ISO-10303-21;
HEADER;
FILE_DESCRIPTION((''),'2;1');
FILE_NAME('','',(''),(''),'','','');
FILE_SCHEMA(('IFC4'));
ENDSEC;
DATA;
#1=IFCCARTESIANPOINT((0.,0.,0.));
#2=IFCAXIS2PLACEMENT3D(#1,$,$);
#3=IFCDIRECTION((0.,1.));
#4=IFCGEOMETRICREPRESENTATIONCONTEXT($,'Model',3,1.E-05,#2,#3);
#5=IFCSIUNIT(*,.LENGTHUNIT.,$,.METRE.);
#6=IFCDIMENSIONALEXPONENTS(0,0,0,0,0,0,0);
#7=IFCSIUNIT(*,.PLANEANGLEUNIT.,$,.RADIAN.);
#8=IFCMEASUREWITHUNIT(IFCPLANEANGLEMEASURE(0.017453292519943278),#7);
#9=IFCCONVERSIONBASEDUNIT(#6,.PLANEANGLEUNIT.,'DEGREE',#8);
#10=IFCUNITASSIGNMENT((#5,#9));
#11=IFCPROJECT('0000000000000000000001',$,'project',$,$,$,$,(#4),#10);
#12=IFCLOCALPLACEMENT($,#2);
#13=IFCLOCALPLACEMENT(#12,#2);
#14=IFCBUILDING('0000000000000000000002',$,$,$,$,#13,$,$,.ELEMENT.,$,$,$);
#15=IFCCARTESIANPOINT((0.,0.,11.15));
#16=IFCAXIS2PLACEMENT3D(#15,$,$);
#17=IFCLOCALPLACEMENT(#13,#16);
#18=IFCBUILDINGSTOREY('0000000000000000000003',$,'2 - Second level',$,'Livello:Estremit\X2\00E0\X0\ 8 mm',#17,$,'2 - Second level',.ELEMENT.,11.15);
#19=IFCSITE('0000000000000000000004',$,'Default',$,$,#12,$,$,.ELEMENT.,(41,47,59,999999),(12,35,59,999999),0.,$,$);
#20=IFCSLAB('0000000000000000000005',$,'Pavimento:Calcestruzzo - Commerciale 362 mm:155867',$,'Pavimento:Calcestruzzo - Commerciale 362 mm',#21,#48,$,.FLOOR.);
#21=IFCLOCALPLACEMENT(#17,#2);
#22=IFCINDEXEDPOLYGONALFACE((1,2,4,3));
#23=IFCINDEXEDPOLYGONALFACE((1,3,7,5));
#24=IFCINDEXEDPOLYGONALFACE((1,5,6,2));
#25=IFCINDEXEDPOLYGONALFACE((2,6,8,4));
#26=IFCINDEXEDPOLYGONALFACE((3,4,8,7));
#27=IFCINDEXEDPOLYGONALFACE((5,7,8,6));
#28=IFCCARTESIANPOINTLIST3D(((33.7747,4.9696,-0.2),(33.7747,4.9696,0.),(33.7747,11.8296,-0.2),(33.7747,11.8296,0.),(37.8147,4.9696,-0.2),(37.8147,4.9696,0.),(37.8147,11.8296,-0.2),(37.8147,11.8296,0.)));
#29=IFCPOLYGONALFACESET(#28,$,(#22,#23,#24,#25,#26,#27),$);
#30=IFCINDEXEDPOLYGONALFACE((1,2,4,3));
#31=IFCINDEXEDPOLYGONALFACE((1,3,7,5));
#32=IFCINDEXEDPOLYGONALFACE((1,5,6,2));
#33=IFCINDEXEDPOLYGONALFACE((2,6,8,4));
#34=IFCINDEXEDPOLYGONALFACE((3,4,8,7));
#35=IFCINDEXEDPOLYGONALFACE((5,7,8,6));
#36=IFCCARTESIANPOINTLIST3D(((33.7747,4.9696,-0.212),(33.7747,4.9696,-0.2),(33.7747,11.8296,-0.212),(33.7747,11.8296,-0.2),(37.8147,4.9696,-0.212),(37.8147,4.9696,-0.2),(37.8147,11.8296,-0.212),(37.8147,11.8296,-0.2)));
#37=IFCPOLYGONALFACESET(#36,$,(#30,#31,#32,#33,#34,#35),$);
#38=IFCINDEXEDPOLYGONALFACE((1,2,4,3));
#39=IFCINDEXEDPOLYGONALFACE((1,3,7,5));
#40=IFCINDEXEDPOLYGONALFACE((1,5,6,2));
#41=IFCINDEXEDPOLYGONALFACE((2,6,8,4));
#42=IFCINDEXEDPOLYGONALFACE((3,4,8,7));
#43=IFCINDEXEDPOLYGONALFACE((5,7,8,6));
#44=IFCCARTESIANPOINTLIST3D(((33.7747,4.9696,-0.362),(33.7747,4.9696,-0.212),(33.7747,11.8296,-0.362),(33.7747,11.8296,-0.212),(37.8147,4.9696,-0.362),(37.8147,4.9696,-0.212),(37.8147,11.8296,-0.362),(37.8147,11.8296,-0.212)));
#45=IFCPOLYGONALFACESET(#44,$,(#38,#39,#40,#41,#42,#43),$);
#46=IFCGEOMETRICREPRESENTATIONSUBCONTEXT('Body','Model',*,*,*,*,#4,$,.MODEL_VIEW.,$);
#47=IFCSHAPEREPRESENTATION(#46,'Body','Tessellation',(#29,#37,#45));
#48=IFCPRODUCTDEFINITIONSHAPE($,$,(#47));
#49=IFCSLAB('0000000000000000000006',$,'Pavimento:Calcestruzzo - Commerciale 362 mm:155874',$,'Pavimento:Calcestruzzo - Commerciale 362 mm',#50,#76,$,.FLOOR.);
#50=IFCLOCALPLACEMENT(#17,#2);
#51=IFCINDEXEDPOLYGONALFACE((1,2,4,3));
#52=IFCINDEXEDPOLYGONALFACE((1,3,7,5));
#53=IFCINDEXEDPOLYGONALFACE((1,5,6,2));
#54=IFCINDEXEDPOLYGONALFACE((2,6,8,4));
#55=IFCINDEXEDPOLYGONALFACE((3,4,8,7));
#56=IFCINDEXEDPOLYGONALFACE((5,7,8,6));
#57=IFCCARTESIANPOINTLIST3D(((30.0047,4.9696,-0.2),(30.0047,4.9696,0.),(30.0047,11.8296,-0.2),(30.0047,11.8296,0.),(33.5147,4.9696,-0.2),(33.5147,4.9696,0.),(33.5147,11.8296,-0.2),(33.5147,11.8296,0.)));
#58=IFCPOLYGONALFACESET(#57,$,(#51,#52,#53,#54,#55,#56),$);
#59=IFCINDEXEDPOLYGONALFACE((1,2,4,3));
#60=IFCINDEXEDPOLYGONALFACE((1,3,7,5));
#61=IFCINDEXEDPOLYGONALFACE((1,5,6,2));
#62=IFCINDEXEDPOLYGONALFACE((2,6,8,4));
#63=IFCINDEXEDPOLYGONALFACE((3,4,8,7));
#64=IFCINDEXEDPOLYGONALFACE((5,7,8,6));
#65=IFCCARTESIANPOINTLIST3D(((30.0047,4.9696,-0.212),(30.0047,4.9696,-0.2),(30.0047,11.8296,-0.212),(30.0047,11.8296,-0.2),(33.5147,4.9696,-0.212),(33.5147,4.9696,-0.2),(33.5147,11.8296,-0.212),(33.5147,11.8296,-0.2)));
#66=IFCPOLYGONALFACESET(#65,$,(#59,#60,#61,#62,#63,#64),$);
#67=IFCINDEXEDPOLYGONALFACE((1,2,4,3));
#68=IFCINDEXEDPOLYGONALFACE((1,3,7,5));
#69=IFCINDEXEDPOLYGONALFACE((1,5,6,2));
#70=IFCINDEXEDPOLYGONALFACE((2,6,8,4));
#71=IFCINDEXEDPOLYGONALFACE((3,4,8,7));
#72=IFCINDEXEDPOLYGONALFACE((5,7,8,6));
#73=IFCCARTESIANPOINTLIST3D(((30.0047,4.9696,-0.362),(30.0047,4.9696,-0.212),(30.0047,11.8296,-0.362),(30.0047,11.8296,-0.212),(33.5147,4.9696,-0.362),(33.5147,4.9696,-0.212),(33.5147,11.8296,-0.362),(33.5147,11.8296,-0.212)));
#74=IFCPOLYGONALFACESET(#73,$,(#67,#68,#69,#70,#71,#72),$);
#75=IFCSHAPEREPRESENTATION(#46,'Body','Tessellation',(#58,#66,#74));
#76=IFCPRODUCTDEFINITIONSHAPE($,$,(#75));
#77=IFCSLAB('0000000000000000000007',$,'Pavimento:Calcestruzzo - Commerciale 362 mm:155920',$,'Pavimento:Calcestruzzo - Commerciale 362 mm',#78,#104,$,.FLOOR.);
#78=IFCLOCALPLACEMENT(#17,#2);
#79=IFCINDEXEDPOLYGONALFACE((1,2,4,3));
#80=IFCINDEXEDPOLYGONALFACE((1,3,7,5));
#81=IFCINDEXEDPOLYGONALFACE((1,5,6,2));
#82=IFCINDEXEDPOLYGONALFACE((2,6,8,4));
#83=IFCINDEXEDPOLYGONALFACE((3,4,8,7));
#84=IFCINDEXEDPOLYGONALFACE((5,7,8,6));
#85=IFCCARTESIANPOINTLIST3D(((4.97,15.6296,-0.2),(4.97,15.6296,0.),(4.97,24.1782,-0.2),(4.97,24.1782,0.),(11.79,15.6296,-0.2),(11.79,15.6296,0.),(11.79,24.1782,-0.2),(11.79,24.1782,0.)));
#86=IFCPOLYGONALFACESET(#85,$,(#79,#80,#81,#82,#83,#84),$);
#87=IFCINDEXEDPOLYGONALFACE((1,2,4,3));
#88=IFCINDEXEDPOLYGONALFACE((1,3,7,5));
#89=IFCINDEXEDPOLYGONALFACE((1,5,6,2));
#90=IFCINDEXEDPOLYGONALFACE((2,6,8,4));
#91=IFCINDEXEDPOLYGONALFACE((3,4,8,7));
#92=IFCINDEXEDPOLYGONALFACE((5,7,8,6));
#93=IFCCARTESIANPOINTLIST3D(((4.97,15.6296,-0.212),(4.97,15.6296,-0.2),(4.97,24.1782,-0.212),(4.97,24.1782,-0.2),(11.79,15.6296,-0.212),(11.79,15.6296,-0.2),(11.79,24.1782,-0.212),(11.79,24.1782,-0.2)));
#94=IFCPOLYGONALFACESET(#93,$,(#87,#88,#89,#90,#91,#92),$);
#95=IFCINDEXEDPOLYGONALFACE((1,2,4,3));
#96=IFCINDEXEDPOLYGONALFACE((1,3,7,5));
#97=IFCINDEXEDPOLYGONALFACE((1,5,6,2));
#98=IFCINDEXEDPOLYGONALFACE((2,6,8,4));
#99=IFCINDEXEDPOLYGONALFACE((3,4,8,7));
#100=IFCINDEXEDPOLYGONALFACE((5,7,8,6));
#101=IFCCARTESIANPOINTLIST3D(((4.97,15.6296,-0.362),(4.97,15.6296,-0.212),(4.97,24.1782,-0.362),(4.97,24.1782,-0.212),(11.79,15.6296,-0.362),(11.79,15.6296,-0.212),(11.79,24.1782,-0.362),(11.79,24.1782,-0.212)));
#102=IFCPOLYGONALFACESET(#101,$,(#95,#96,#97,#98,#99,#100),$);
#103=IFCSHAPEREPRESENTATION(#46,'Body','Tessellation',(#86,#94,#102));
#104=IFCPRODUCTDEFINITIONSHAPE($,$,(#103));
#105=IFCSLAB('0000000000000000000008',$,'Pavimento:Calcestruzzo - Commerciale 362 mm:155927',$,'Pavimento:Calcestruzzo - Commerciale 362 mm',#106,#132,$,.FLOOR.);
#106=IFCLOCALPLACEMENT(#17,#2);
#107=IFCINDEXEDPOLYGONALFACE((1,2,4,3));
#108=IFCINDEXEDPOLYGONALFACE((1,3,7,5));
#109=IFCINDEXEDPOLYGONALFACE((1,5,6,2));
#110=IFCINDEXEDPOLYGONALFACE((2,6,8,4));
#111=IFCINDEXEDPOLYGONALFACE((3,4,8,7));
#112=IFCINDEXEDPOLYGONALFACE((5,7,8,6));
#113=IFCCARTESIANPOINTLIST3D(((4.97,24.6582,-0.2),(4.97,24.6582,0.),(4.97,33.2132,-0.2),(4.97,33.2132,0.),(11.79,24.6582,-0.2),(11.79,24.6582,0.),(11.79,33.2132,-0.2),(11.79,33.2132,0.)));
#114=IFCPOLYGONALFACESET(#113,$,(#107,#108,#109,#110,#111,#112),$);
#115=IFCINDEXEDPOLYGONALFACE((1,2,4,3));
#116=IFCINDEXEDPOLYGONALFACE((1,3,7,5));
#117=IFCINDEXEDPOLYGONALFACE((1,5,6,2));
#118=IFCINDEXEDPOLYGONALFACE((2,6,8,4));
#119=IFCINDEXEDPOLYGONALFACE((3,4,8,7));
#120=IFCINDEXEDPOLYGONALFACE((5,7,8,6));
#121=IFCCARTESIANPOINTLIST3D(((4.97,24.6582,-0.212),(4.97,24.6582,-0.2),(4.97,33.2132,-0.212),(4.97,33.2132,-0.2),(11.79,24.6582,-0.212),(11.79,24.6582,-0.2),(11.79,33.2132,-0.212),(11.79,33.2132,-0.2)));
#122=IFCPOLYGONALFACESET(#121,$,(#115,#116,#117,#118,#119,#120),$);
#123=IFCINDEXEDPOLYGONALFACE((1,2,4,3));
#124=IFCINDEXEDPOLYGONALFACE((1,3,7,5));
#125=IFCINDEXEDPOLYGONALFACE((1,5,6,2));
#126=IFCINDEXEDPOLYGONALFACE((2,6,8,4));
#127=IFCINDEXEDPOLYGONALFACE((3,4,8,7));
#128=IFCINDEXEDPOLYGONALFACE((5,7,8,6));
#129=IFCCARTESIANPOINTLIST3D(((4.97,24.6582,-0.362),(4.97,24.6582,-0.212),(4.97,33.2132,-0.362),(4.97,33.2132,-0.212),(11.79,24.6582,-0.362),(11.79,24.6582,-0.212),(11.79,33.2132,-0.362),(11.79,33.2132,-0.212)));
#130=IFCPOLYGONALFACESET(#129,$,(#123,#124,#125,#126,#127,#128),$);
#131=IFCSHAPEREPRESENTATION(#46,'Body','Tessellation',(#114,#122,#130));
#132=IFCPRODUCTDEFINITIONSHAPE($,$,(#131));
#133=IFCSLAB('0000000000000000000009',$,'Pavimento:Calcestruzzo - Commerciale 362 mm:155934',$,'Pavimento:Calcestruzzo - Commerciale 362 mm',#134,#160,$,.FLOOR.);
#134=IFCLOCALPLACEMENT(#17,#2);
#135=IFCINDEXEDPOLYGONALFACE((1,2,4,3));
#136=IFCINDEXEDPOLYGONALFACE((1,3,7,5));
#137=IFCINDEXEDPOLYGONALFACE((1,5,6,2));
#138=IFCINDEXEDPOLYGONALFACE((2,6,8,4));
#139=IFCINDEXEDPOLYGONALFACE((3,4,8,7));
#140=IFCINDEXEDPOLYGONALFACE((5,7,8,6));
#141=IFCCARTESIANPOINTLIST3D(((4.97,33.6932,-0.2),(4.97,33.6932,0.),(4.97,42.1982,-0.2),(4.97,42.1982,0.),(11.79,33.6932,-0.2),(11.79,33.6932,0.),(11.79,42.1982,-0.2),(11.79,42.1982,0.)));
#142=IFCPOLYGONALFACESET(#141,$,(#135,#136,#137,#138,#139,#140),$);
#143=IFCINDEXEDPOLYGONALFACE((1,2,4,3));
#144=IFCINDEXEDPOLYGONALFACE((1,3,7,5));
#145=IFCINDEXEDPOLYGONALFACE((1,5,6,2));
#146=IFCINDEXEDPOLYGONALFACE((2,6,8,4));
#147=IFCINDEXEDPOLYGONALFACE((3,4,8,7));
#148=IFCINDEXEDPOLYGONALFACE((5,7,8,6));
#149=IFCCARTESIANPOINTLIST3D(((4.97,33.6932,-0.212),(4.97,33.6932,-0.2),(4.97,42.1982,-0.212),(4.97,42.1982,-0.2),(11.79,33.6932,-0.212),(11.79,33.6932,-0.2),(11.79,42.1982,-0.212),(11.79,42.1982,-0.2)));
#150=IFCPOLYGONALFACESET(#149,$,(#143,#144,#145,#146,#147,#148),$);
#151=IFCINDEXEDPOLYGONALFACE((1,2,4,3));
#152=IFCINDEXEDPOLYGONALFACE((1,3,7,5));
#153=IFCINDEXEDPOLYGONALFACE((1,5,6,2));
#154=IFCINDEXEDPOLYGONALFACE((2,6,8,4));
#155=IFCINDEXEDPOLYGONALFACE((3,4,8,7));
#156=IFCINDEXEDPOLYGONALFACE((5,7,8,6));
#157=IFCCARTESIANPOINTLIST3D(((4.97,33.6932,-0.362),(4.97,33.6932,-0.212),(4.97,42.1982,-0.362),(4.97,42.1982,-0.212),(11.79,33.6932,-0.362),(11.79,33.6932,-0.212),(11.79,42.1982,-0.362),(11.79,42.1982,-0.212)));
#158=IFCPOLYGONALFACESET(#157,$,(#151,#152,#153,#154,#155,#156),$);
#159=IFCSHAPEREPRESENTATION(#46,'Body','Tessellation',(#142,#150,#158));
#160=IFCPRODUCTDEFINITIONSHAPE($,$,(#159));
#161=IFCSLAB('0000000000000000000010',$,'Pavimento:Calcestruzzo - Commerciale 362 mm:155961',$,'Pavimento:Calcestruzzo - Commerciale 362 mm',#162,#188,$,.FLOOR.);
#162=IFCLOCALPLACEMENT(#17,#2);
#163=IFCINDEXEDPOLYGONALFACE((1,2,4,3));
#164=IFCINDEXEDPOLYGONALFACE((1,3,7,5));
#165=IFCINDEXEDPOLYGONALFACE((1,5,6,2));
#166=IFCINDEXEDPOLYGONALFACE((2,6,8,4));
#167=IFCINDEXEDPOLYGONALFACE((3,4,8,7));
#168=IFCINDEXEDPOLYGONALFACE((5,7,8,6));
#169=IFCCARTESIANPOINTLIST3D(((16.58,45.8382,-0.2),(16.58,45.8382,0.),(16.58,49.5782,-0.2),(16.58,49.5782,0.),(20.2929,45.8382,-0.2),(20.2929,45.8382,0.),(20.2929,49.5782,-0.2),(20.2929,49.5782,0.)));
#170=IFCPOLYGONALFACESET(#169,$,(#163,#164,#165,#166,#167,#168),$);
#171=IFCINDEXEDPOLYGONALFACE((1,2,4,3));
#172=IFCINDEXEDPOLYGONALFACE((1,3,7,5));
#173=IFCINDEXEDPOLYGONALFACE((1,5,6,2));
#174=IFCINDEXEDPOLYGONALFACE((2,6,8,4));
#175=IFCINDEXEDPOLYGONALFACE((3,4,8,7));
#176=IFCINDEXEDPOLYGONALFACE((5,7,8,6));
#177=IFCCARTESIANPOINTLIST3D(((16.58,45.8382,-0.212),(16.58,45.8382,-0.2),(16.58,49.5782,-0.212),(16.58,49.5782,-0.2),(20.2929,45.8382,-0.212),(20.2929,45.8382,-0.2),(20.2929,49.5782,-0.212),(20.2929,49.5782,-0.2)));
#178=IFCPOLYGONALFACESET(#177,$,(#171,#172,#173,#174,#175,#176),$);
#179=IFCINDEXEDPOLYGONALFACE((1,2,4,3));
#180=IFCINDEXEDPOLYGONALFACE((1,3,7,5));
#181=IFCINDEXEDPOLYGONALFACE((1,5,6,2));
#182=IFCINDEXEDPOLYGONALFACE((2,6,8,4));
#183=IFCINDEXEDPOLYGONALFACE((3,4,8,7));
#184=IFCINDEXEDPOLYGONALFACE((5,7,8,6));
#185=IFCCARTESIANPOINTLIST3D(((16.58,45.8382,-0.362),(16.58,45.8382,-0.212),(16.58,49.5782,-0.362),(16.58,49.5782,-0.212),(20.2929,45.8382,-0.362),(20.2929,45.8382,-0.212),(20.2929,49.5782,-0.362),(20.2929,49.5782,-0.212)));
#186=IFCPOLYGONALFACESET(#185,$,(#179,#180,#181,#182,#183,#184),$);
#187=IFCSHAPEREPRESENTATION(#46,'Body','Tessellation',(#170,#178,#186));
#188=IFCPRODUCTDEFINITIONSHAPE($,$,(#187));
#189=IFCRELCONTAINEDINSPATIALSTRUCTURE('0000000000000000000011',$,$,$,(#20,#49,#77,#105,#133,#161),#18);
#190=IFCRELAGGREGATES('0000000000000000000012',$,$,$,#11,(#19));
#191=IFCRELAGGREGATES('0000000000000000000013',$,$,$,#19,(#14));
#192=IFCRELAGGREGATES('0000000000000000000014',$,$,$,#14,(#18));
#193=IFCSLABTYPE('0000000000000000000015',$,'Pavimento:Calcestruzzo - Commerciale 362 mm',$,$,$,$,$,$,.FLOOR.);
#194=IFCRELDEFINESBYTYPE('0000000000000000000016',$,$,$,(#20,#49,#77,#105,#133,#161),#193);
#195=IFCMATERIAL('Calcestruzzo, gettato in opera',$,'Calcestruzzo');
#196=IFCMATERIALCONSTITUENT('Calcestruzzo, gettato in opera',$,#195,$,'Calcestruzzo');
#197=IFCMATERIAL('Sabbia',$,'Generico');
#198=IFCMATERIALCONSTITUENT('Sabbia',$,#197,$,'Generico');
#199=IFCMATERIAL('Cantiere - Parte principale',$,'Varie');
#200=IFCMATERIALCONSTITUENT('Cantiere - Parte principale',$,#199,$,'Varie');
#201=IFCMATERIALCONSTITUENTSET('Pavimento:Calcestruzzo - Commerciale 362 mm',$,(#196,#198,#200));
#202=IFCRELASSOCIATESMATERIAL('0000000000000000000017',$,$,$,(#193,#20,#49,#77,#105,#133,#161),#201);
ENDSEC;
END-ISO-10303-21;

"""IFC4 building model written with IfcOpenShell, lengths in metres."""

from ifc_helpers import new_model, entity, si_unit, converted_unit, direction, frame, origin, place, context, subcontext, project, spatial, indexed_curve, outline, extrude, material, constituent, constituent_set, type_object, element, save


model = new_model("IFC4")

# Units and contexts
model_context = context("Model", 3, precision=1e-05, world=origin(), true_north=direction((0.0, 1.0)))
body_context = subcontext(model_context, "Body", "Model", "MODEL_VIEW")
ifc_project = project(units=[si_unit("LENGTHUNIT", "METRE"), converted_unit("PLANEANGLEUNIT", "DEGREE", entity("IfcPlaneAngleMeasure", 0.017453292519943278), si_unit("PLANEANGLEUNIT", "RADIAN"), dimensions=[0, 0, 0, 0, 0, 0, 0])], contexts=[model_context])

# Site, building, storey
site_placement = place(None, origin())
site = spatial("IfcSite", under=ifc_project, at=site_placement, Name="Default", CompositionType="ELEMENT", RefLatitude=(41, 47, 59, 999999), RefLongitude=(12, 35, 59, 999999), RefElevation=0.0)
building_placement = place(site_placement, origin())
building = spatial("IfcBuilding", under=site, at=building_placement, CompositionType="ELEMENT")
storey_placement = place(building_placement, frame((0.0, 0.0, 11.15)))
storey = spatial("IfcBuildingStorey", under=building, at=storey_placement, Name="2 - Second level", ObjectType="Livello:Estremità 8 mm", LongName="2 - Second level", CompositionType="ELEMENT", Elevation=11.15)

# Slabs
ifc_material_1 = material(Name="Calcestruzzo, gettato in opera", Category="Calcestruzzo")
ifc_constituent_1 = constituent(ifc_material_1, Name="Calcestruzzo, gettato in opera", Category="Calcestruzzo")
ifc_material_2 = material(Name="Sabbia", Category="Generico")
ifc_constituent_2 = constituent(ifc_material_2, Name="Sabbia", Category="Generico")
ifc_material_3 = material(Name="Cantiere - Parte principale", Category="Varie")
ifc_constituent_3 = constituent(ifc_material_3, Name="Cantiere - Parte principale", Category="Varie")
ifc_constituent_set = constituent_set(constituents=[ifc_constituent_1, ifc_constituent_2, ifc_constituent_3], Name="Pavimento:Calcestruzzo - Commerciale 362 mm")
slab_type = type_object("IfcSlabType", Name="Pavimento:Calcestruzzo - Commerciale 362 mm", PredefinedType="FLOOR", material=ifc_constituent_set)
slab_1_placement = place(storey_placement, origin())
element("IfcSlab", 1, at=slab_1_placement, inside=storey, type_object=slab_type, material=ifc_constituent_set, Name="Pavimento:Calcestruzzo - Commerciale 362 mm:155867", ObjectType="Pavimento:Calcestruzzo - Commerciale 362 mm", PredefinedType="FLOOR", context=body_context, shape_type="SweptSolid", body=[
    extrude(outline(indexed_curve([(-2.02, -3.43), (2.02, -3.43), (2.02, 3.43), (-2.02, 3.43), (-2.02, -3.43)], self_intersect=False)), frame((35.7947, 8.3996, -0.2)), (0.0, 0.0, 1.0), 0.2),
    extrude(outline(indexed_curve([(-2.02, -3.43), (2.02, -3.43), (2.02, 3.43), (-2.02, 3.43), (-2.02, -3.43)], self_intersect=False)), frame((35.7947, 8.3996, -0.212)), (0.0, 0.0, 1.0), 0.012),
    extrude(outline(indexed_curve([(-2.02, -3.43), (2.02, -3.43), (2.02, 3.43), (-2.02, 3.43), (-2.02, -3.43)], self_intersect=False)), frame((35.7947, 8.3996, -0.362)), (0.0, 0.0, 1.0), 0.15),
])
slab_2_placement = place(storey_placement, origin())
element("IfcSlab", 2, at=slab_2_placement, inside=storey, type_object=slab_type, material=ifc_constituent_set, Name="Pavimento:Calcestruzzo - Commerciale 362 mm:155874", ObjectType="Pavimento:Calcestruzzo - Commerciale 362 mm", PredefinedType="FLOOR", context=body_context, shape_type="SweptSolid", body=[
    extrude(outline(indexed_curve([(-1.755, -3.43), (1.755, -3.43), (1.755, 3.43), (-1.755, 3.43), (-1.755, -3.43)], self_intersect=False)), frame((31.7597, 8.3996, -0.2)), (0.0, 0.0, 1.0), 0.2),
    extrude(outline(indexed_curve([(-1.755, -3.43), (1.755, -3.43), (1.755, 3.43), (-1.755, 3.43), (-1.755, -3.43)], self_intersect=False)), frame((31.7597, 8.3996, -0.212)), (0.0, 0.0, 1.0), 0.012),
    extrude(outline(indexed_curve([(-1.755, -3.43), (1.755, -3.43), (1.755, 3.43), (-1.755, 3.43), (-1.755, -3.43)], self_intersect=False)), frame((31.7597, 8.3996, -0.362)), (0.0, 0.0, 1.0), 0.15),
])
slab_3_placement = place(storey_placement, origin())
element("IfcSlab", 3, at=slab_3_placement, inside=storey, type_object=slab_type, material=ifc_constituent_set, Name="Pavimento:Calcestruzzo - Commerciale 362 mm:155920", ObjectType="Pavimento:Calcestruzzo - Commerciale 362 mm", PredefinedType="FLOOR", context=body_context, shape_type="SweptSolid", body=[
    extrude(outline(indexed_curve([(-3.41, -4.2743), (3.41, -4.2743), (3.41, 4.2743), (-3.41, 4.2743), (-3.41, -4.2743)], self_intersect=False)), frame((8.38, 19.9039, -0.2), z_axis=(0.0, 0.0, 1.0), x_axis=(-1.0, 0.0, 0.0)), (0.0, 0.0, 1.0), 0.2),
    extrude(outline(indexed_curve([(-3.41, -4.2743), (3.41, -4.2743), (3.41, 4.2743), (-3.41, 4.2743), (-3.41, -4.2743)], self_intersect=False)), frame((8.38, 19.9039, -0.212), z_axis=(0.0, 0.0, 1.0), x_axis=(-1.0, 0.0, 0.0)), (0.0, 0.0, 1.0), 0.012),
    extrude(outline(indexed_curve([(-3.41, -4.2743), (3.41, -4.2743), (3.41, 4.2743), (-3.41, 4.2743), (-3.41, -4.2743)], self_intersect=False)), frame((8.38, 19.9039, -0.362), z_axis=(0.0, 0.0, 1.0), x_axis=(-1.0, 0.0, 0.0)), (0.0, 0.0, 1.0), 0.15),
])
slab_4_placement = place(storey_placement, origin())
element("IfcSlab", 4, at=slab_4_placement, inside=storey, type_object=slab_type, material=ifc_constituent_set, Name="Pavimento:Calcestruzzo - Commerciale 362 mm:155927", ObjectType="Pavimento:Calcestruzzo - Commerciale 362 mm", PredefinedType="FLOOR", context=body_context, shape_type="SweptSolid", body=[
    extrude(outline(indexed_curve([(-3.41, -4.2775), (3.41, -4.2775), (3.41, 4.2775), (-3.41, 4.2775), (-3.41, -4.2775)], self_intersect=False)), frame((8.38, 28.9357, -0.2)), (0.0, 0.0, 1.0), 0.2),
    extrude(outline(indexed_curve([(-3.41, -4.2775), (3.41, -4.2775), (3.41, 4.2775), (-3.41, 4.2775), (-3.41, -4.2775)], self_intersect=False)), frame((8.38, 28.9357, -0.212)), (0.0, 0.0, 1.0), 0.012),
    extrude(outline(indexed_curve([(-3.41, -4.2775), (3.41, -4.2775), (3.41, 4.2775), (-3.41, 4.2775), (-3.41, -4.2775)], self_intersect=False)), frame((8.38, 28.9357, -0.362)), (0.0, 0.0, 1.0), 0.15),
])
slab_5_placement = place(storey_placement, origin())
element("IfcSlab", 5, at=slab_5_placement, inside=storey, type_object=slab_type, material=ifc_constituent_set, Name="Pavimento:Calcestruzzo - Commerciale 362 mm:155934", ObjectType="Pavimento:Calcestruzzo - Commerciale 362 mm", PredefinedType="FLOOR", context=body_context, shape_type="SweptSolid", body=[
    extrude(outline(indexed_curve([(-3.41, -4.2525), (3.41, -4.2525), (3.41, 4.2525), (-3.41, 4.2525), (-3.41, -4.2525)], self_intersect=False)), frame((8.38, 37.9457, -0.2)), (0.0, 0.0, 1.0), 0.2),
    extrude(outline(indexed_curve([(-3.41, -4.2525), (3.41, -4.2525), (3.41, 4.2525), (-3.41, 4.2525), (-3.41, -4.2525)], self_intersect=False)), frame((8.38, 37.9457, -0.212)), (0.0, 0.0, 1.0), 0.012),
    extrude(outline(indexed_curve([(-3.41, -4.2525), (3.41, -4.2525), (3.41, 4.2525), (-3.41, 4.2525), (-3.41, -4.2525)], self_intersect=False)), frame((8.38, 37.9457, -0.362)), (0.0, 0.0, 1.0), 0.15),
])
slab_6_placement = place(storey_placement, origin())
element("IfcSlab", 6, at=slab_6_placement, inside=storey, type_object=slab_type, material=ifc_constituent_set, Name="Pavimento:Calcestruzzo - Commerciale 362 mm:155961", ObjectType="Pavimento:Calcestruzzo - Commerciale 362 mm", PredefinedType="FLOOR", context=body_context, shape_type="SweptSolid", body=[
    extrude(outline(indexed_curve([(-1.8565, -1.87), (1.8565, -1.87), (1.8565, 1.87), (-1.8565, 1.87), (-1.8565, -1.87)], self_intersect=False)), frame((18.4365, 47.7082, -0.2), z_axis=(0.0, 0.0, 1.0), x_axis=(-1.0, 0.0, 0.0)), (0.0, 0.0, 1.0), 0.2),
    extrude(outline(indexed_curve([(-1.8565, -1.87), (1.8565, -1.87), (1.8565, 1.87), (-1.8565, 1.87), (-1.8565, -1.87)], self_intersect=False)), frame((18.4365, 47.7082, -0.212), z_axis=(0.0, 0.0, 1.0), x_axis=(-1.0, 0.0, 0.0)), (0.0, 0.0, 1.0), 0.012),
    extrude(outline(indexed_curve([(-1.8565, -1.87), (1.8565, -1.87), (1.8565, 1.87), (-1.8565, 1.87), (-1.8565, -1.87)], self_intersect=False)), frame((18.4365, 47.7082, -0.362), z_axis=(0.0, 0.0, 1.0), x_axis=(-1.0, 0.0, 0.0)), (0.0, 0.0, 1.0), 0.15),
])

save(model, "model.ifc")
